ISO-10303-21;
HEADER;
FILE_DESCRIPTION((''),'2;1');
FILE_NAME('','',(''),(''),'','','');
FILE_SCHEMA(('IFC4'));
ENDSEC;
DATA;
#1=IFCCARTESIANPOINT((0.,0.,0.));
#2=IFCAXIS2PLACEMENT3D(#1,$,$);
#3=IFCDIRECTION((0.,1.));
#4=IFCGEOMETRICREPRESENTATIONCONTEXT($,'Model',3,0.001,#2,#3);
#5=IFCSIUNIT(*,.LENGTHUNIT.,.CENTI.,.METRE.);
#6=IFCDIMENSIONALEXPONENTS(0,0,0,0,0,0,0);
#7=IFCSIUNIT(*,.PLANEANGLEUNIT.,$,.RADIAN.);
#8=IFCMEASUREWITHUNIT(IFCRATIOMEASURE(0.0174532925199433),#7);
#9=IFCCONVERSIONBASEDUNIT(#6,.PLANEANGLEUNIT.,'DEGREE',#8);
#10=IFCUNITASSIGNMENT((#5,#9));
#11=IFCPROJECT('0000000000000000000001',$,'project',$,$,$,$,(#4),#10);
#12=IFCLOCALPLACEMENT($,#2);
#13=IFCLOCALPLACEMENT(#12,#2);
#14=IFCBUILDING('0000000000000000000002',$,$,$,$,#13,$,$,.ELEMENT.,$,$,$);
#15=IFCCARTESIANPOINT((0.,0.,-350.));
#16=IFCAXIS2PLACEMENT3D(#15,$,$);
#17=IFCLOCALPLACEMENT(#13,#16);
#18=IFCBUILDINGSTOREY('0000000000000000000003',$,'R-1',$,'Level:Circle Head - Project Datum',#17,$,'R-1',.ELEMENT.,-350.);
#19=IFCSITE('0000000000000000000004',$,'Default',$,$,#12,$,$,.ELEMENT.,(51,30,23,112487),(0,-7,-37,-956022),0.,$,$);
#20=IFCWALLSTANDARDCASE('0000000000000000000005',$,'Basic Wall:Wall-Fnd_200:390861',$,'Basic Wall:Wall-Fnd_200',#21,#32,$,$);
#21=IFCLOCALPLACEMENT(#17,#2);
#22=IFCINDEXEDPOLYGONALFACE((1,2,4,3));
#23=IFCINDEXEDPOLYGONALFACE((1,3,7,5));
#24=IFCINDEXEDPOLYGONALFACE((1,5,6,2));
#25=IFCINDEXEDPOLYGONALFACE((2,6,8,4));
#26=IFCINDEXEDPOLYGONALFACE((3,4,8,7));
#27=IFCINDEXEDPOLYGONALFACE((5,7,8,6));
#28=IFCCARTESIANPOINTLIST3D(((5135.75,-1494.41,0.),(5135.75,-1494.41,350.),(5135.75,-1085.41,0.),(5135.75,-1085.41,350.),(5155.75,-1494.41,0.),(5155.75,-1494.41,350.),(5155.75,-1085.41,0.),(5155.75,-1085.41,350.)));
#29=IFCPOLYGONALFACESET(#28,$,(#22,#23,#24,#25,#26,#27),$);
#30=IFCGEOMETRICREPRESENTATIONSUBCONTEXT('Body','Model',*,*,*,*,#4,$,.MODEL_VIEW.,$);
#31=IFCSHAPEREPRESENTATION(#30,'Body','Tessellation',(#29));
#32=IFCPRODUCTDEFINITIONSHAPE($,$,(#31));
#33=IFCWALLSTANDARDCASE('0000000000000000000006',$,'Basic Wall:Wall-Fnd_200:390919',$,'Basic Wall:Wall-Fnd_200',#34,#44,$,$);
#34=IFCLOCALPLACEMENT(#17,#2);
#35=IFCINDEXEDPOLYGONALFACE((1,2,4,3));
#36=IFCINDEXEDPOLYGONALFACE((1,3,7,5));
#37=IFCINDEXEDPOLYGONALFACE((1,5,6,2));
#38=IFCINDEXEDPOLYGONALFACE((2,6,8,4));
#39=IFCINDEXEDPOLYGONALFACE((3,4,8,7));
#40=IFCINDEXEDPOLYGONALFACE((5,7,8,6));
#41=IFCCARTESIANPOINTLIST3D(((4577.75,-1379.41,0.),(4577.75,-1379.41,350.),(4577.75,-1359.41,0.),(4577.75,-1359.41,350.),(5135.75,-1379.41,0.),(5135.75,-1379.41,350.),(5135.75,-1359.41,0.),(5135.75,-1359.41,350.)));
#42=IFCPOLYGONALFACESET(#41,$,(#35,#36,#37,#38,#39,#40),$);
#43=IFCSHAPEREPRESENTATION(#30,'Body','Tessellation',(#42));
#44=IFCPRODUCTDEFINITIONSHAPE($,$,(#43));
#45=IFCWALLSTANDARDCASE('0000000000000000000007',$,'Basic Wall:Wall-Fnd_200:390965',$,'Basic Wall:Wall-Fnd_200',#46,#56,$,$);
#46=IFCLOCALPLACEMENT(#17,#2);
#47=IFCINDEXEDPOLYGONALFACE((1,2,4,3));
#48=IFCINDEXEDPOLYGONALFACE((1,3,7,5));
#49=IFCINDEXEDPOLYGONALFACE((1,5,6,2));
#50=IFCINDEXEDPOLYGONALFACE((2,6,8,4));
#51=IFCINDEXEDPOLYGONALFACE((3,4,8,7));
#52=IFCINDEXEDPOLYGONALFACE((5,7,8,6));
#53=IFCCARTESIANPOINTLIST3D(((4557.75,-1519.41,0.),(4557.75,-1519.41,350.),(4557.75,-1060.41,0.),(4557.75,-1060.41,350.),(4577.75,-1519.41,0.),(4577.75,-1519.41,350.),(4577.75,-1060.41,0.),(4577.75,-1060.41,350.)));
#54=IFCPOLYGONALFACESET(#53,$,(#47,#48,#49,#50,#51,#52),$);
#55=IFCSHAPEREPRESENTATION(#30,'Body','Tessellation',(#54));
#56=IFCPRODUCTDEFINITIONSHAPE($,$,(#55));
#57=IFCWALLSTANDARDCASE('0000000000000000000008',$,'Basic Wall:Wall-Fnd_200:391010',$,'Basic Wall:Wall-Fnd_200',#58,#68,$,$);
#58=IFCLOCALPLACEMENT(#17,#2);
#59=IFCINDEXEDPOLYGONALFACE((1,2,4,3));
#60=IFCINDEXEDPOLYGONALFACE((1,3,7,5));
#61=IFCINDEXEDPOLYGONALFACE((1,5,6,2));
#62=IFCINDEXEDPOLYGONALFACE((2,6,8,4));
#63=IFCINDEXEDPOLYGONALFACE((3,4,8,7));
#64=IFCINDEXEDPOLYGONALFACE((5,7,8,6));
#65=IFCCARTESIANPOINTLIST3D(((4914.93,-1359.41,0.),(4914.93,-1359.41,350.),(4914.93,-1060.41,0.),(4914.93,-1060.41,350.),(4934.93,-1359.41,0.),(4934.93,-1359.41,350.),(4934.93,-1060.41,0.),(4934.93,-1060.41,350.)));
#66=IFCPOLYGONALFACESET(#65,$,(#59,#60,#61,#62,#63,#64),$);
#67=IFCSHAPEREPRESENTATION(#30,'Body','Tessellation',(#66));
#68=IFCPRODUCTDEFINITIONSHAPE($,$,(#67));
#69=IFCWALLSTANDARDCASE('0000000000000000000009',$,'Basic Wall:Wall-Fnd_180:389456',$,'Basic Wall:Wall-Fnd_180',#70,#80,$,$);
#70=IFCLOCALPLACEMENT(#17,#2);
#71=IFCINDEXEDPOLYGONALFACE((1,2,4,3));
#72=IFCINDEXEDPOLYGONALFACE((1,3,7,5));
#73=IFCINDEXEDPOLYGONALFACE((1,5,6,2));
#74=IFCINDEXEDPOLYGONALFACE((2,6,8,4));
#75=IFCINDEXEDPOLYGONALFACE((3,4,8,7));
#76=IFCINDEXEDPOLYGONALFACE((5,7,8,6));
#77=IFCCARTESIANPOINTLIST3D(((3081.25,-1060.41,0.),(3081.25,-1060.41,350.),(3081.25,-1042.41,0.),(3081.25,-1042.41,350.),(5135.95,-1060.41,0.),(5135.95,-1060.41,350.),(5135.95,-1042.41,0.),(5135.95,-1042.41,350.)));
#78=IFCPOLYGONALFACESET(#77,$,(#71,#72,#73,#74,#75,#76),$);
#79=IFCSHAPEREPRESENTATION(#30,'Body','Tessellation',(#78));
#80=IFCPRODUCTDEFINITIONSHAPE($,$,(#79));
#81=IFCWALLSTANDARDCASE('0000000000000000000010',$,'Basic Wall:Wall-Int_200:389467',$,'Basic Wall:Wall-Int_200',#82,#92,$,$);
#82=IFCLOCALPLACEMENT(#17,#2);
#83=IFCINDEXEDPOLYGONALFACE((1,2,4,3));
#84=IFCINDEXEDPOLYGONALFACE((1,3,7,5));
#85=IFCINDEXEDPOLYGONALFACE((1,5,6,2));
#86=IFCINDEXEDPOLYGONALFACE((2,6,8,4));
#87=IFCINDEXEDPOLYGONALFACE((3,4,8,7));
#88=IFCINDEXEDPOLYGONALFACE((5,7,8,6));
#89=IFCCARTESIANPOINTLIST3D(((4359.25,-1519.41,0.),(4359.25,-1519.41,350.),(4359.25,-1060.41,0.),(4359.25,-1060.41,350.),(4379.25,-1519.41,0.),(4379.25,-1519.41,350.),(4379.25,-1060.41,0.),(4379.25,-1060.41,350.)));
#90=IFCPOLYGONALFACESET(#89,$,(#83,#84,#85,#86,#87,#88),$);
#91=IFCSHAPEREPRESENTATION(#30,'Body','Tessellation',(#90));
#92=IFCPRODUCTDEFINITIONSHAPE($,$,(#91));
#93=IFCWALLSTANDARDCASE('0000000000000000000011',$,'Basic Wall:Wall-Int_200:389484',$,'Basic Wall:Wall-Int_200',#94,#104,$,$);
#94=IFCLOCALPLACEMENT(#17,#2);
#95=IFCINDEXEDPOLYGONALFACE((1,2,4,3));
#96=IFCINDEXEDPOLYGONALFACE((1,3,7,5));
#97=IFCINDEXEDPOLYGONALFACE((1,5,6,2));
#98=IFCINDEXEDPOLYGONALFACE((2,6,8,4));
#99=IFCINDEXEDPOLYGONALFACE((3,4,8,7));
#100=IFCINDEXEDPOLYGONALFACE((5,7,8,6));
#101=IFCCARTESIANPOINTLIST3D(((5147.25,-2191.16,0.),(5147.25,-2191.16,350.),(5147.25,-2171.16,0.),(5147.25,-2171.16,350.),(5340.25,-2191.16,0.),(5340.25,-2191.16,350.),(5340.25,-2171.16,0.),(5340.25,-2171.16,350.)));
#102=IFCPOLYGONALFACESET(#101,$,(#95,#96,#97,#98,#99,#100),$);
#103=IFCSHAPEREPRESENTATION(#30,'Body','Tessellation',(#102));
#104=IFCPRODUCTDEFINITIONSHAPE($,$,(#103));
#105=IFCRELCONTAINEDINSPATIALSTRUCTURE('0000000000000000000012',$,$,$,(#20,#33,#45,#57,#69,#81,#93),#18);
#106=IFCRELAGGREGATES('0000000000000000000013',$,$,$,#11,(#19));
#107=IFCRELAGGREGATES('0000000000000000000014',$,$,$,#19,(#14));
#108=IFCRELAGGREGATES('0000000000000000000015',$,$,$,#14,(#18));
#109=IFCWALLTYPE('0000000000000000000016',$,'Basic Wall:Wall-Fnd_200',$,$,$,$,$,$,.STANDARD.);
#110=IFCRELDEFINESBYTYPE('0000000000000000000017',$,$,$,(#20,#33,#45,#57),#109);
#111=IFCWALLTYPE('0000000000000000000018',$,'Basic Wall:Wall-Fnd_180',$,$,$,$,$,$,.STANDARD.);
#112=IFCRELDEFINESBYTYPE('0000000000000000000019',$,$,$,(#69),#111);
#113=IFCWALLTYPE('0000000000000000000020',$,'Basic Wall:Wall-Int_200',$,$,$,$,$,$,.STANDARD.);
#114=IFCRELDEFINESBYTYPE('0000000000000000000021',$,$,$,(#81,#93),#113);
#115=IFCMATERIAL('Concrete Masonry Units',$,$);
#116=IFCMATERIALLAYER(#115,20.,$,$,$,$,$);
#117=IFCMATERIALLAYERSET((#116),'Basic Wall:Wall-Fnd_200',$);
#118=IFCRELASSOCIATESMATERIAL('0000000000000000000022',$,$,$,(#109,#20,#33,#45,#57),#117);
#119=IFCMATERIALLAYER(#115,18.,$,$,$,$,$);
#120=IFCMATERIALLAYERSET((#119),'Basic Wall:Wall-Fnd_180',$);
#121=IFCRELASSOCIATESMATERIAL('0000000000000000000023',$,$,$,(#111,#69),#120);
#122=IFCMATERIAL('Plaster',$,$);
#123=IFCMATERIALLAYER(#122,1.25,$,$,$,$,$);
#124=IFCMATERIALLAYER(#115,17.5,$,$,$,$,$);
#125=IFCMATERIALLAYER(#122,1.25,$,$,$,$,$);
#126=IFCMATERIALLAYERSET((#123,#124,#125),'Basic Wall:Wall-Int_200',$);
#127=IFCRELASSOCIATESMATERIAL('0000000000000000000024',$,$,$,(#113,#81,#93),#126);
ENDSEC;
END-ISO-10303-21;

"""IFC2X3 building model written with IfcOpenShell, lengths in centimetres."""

from ifc_helpers import new_model, entity, si_unit, converted_unit, direction, frame, frame_2d, origin, place, context, subcontext, project, spatial, rectangle, extrude, material, layer, layer_set, layer_usage, type_object, element, save


model = new_model("IFC2X3")

# Units and contexts
model_context = context("Model", 3, precision=0.001, world=origin(), true_north=direction((0.0, 1.0)))
body_context = subcontext(model_context, "Body", "Model", "MODEL_VIEW")
ifc_project = project(units=[si_unit("LENGTHUNIT", "METRE", prefix="CENTI"), converted_unit("PLANEANGLEUNIT", "DEGREE", entity("IfcRatioMeasure", 0.0174532925199433), si_unit("PLANEANGLEUNIT", "RADIAN"), dimensions=[0, 0, 0, 0, 0, 0, 0])], contexts=[model_context])

# Site, building, storey
site_placement = place(None, origin())
site = spatial("IfcSite", under=ifc_project, at=site_placement, Name="Default", CompositionType="ELEMENT", RefLatitude=(51, 30, 23, 112487), RefLongitude=(0, -7, -37, -956022), RefElevation=0.0)
building_placement = place(site_placement, origin())
building = spatial("IfcBuilding", under=site, at=building_placement, CompositionType="ELEMENT")
storey_placement = place(building_placement, frame((0.0, 0.0, -350.0)))
storey = spatial("IfcBuildingStorey", under=building, at=storey_placement, Name="R-1", ObjectType="Level:Circle Head - Project Datum", LongName="R-1", CompositionType="ELEMENT", Elevation=-350.0)

# Walls
ifc_material_1 = material(Name="Concrete Masonry Units")
ifc_layer_1 = layer(ifc_material_1, 20.0)
ifc_layer_set_1 = layer_set([ifc_layer_1], Name="Basic Wall:Wall-Fnd_200")
wall_type_1 = type_object("IfcWallType", Name="Basic Wall:Wall-Fnd_200", PredefinedType="STANDARD", material=ifc_layer_set_1)
ifc_layer_usage_1 = layer_usage(ifc_layer_set_1, "AXIS2", "NEGATIVE", 10.0)
wall_1_placement = place(storey_placement, frame((5145.75, -1494.41, 0.0), z_axis=(0.0, 0.0, 1.0), x_axis=(0.0, 1.0, 0.0)))
element("IfcWallStandardCase", 1, at=wall_1_placement, inside=storey, type_object=wall_type_1, material=ifc_layer_usage_1, Name="Basic Wall:Wall-Fnd_200:390861", ObjectType="Basic Wall:Wall-Fnd_200", context=body_context, shape_type="SweptSolid", body=[
    extrude(rectangle(XDim=409.0, YDim=20.0, at=frame_2d((204.5, 0.0), x_axis=(-1.0, 0.0))), origin(), (0.0, 0.0, 1.0), 350.0),
])
ifc_layer_usage_2 = layer_usage(ifc_layer_set_1, "AXIS2", "NEGATIVE", 10.0)
wall_2_placement = place(storey_placement, frame((5135.75, -1369.41, 0.0), z_axis=(0.0, 0.0, 1.0), x_axis=(-1.0, 0.0, 0.0)))
element("IfcWallStandardCase", 2, at=wall_2_placement, inside=storey, type_object=wall_type_1, material=ifc_layer_usage_2, Name="Basic Wall:Wall-Fnd_200:390919", ObjectType="Basic Wall:Wall-Fnd_200", context=body_context, shape_type="SweptSolid", body=[
    extrude(rectangle(XDim=558.0, YDim=20.0, at=frame_2d((279.0, 0.0), x_axis=(-1.0, 0.0))), origin(), (0.0, 0.0, 1.0), 350.0),
])
ifc_layer_usage_3 = layer_usage(ifc_layer_set_1, "AXIS2", "NEGATIVE", 10.0)
wall_3_placement = place(storey_placement, frame((4567.75, -1519.41, 0.0), z_axis=(0.0, 0.0, 1.0), x_axis=(0.0, 1.0, 0.0)))
element("IfcWallStandardCase", 3, at=wall_3_placement, inside=storey, type_object=wall_type_1, material=ifc_layer_usage_3, Name="Basic Wall:Wall-Fnd_200:390965", ObjectType="Basic Wall:Wall-Fnd_200", context=body_context, shape_type="SweptSolid", body=[
    extrude(rectangle(XDim=459.0, YDim=20.0, at=frame_2d((229.5, 0.0), x_axis=(-1.0, 0.0))), origin(), (0.0, 0.0, 1.0), 350.0),
])
ifc_layer_usage_4 = layer_usage(ifc_layer_set_1, "AXIS2", "NEGATIVE", 10.0)
wall_4_placement = place(storey_placement, frame((4924.93, -1359.41, 0.0), z_axis=(0.0, 0.0, 1.0), x_axis=(0.0, 1.0, 0.0)))
element("IfcWallStandardCase", 4, at=wall_4_placement, inside=storey, type_object=wall_type_1, material=ifc_layer_usage_4, Name="Basic Wall:Wall-Fnd_200:391010", ObjectType="Basic Wall:Wall-Fnd_200", context=body_context, shape_type="SweptSolid", body=[
    extrude(rectangle(XDim=299.0, YDim=20.0, at=frame_2d((149.5, 0.0), x_axis=(-1.0, 0.0))), origin(), (0.0, 0.0, 1.0), 350.0),
])
ifc_layer_2 = layer(ifc_material_1, 18.0)
ifc_layer_set_2 = layer_set([ifc_layer_2], Name="Basic Wall:Wall-Fnd_180")
ifc_layer_usage_5 = layer_usage(ifc_layer_set_2, "AXIS2", "POSITIVE", -9.0)
wall_type_2 = type_object("IfcWallType", Name="Basic Wall:Wall-Fnd_180", PredefinedType="STANDARD", material=ifc_layer_set_2)
wall_5_placement = place(storey_placement, frame((5135.95, -1051.41, 0.0), z_axis=(0.0, 0.0, 1.0), x_axis=(-1.0, 0.0, 0.0)))
element("IfcWallStandardCase", 5, at=wall_5_placement, inside=storey, type_object=wall_type_2, material=ifc_layer_usage_5, Name="Basic Wall:Wall-Fnd_180:389456", ObjectType="Basic Wall:Wall-Fnd_180", context=body_context, shape_type="SweptSolid", body=[
    extrude(rectangle(XDim=2054.7, YDim=18.0, at=frame_2d((1027.35, 0.0), x_axis=(-1.0, 0.0))), origin(), (0.0, 0.0, 1.0), 350.0),
])
ifc_material_2 = material(Name="Plaster")
ifc_layer_3 = layer(ifc_material_2, 1.25)
ifc_layer_4 = layer(ifc_material_1, 17.5)
ifc_layer_5 = layer(ifc_material_2, 1.25)
ifc_layer_set_3 = layer_set([ifc_layer_3, ifc_layer_4, ifc_layer_5], Name="Basic Wall:Wall-Int_200")
ifc_layer_usage_6 = layer_usage(ifc_layer_set_3, "AXIS2", "POSITIVE", -10.0)
wall_type_3 = type_object("IfcWallType", Name="Basic Wall:Wall-Int_200", PredefinedType="STANDARD", material=ifc_layer_set_3)
wall_6_placement = place(storey_placement, frame((4369.25, -1519.41, 0.0), z_axis=(0.0, 0.0, 1.0), x_axis=(0.0, 1.0, 0.0)))
element("IfcWallStandardCase", 6, at=wall_6_placement, inside=storey, type_object=wall_type_3, material=ifc_layer_usage_6, Name="Basic Wall:Wall-Int_200:389467", ObjectType="Basic Wall:Wall-Int_200", context=body_context, shape_type="SweptSolid", body=[
    extrude(rectangle(XDim=459.0, YDim=20.0, at=frame_2d((229.5, 0.0), x_axis=(-1.0, 0.0))), origin(), (0.0, 0.0, 1.0), 350.0),
])
ifc_layer_usage_7 = layer_usage(ifc_layer_set_3, "AXIS2", "NEGATIVE", 10.0)
wall_7_placement = place(storey_placement, frame((5147.25, -2181.16, 0.0)))
element("IfcWallStandardCase", 7, at=wall_7_placement, inside=storey, type_object=wall_type_3, material=ifc_layer_usage_7, Name="Basic Wall:Wall-Int_200:389484", ObjectType="Basic Wall:Wall-Int_200", context=body_context, shape_type="SweptSolid", body=[
    extrude(rectangle(XDim=193.0, YDim=20.0, at=frame_2d((96.5, 0.0), x_axis=(-1.0, 0.0))), origin(), (0.0, 0.0, 1.0), 350.0),
])

save(model, "model.ifc")
